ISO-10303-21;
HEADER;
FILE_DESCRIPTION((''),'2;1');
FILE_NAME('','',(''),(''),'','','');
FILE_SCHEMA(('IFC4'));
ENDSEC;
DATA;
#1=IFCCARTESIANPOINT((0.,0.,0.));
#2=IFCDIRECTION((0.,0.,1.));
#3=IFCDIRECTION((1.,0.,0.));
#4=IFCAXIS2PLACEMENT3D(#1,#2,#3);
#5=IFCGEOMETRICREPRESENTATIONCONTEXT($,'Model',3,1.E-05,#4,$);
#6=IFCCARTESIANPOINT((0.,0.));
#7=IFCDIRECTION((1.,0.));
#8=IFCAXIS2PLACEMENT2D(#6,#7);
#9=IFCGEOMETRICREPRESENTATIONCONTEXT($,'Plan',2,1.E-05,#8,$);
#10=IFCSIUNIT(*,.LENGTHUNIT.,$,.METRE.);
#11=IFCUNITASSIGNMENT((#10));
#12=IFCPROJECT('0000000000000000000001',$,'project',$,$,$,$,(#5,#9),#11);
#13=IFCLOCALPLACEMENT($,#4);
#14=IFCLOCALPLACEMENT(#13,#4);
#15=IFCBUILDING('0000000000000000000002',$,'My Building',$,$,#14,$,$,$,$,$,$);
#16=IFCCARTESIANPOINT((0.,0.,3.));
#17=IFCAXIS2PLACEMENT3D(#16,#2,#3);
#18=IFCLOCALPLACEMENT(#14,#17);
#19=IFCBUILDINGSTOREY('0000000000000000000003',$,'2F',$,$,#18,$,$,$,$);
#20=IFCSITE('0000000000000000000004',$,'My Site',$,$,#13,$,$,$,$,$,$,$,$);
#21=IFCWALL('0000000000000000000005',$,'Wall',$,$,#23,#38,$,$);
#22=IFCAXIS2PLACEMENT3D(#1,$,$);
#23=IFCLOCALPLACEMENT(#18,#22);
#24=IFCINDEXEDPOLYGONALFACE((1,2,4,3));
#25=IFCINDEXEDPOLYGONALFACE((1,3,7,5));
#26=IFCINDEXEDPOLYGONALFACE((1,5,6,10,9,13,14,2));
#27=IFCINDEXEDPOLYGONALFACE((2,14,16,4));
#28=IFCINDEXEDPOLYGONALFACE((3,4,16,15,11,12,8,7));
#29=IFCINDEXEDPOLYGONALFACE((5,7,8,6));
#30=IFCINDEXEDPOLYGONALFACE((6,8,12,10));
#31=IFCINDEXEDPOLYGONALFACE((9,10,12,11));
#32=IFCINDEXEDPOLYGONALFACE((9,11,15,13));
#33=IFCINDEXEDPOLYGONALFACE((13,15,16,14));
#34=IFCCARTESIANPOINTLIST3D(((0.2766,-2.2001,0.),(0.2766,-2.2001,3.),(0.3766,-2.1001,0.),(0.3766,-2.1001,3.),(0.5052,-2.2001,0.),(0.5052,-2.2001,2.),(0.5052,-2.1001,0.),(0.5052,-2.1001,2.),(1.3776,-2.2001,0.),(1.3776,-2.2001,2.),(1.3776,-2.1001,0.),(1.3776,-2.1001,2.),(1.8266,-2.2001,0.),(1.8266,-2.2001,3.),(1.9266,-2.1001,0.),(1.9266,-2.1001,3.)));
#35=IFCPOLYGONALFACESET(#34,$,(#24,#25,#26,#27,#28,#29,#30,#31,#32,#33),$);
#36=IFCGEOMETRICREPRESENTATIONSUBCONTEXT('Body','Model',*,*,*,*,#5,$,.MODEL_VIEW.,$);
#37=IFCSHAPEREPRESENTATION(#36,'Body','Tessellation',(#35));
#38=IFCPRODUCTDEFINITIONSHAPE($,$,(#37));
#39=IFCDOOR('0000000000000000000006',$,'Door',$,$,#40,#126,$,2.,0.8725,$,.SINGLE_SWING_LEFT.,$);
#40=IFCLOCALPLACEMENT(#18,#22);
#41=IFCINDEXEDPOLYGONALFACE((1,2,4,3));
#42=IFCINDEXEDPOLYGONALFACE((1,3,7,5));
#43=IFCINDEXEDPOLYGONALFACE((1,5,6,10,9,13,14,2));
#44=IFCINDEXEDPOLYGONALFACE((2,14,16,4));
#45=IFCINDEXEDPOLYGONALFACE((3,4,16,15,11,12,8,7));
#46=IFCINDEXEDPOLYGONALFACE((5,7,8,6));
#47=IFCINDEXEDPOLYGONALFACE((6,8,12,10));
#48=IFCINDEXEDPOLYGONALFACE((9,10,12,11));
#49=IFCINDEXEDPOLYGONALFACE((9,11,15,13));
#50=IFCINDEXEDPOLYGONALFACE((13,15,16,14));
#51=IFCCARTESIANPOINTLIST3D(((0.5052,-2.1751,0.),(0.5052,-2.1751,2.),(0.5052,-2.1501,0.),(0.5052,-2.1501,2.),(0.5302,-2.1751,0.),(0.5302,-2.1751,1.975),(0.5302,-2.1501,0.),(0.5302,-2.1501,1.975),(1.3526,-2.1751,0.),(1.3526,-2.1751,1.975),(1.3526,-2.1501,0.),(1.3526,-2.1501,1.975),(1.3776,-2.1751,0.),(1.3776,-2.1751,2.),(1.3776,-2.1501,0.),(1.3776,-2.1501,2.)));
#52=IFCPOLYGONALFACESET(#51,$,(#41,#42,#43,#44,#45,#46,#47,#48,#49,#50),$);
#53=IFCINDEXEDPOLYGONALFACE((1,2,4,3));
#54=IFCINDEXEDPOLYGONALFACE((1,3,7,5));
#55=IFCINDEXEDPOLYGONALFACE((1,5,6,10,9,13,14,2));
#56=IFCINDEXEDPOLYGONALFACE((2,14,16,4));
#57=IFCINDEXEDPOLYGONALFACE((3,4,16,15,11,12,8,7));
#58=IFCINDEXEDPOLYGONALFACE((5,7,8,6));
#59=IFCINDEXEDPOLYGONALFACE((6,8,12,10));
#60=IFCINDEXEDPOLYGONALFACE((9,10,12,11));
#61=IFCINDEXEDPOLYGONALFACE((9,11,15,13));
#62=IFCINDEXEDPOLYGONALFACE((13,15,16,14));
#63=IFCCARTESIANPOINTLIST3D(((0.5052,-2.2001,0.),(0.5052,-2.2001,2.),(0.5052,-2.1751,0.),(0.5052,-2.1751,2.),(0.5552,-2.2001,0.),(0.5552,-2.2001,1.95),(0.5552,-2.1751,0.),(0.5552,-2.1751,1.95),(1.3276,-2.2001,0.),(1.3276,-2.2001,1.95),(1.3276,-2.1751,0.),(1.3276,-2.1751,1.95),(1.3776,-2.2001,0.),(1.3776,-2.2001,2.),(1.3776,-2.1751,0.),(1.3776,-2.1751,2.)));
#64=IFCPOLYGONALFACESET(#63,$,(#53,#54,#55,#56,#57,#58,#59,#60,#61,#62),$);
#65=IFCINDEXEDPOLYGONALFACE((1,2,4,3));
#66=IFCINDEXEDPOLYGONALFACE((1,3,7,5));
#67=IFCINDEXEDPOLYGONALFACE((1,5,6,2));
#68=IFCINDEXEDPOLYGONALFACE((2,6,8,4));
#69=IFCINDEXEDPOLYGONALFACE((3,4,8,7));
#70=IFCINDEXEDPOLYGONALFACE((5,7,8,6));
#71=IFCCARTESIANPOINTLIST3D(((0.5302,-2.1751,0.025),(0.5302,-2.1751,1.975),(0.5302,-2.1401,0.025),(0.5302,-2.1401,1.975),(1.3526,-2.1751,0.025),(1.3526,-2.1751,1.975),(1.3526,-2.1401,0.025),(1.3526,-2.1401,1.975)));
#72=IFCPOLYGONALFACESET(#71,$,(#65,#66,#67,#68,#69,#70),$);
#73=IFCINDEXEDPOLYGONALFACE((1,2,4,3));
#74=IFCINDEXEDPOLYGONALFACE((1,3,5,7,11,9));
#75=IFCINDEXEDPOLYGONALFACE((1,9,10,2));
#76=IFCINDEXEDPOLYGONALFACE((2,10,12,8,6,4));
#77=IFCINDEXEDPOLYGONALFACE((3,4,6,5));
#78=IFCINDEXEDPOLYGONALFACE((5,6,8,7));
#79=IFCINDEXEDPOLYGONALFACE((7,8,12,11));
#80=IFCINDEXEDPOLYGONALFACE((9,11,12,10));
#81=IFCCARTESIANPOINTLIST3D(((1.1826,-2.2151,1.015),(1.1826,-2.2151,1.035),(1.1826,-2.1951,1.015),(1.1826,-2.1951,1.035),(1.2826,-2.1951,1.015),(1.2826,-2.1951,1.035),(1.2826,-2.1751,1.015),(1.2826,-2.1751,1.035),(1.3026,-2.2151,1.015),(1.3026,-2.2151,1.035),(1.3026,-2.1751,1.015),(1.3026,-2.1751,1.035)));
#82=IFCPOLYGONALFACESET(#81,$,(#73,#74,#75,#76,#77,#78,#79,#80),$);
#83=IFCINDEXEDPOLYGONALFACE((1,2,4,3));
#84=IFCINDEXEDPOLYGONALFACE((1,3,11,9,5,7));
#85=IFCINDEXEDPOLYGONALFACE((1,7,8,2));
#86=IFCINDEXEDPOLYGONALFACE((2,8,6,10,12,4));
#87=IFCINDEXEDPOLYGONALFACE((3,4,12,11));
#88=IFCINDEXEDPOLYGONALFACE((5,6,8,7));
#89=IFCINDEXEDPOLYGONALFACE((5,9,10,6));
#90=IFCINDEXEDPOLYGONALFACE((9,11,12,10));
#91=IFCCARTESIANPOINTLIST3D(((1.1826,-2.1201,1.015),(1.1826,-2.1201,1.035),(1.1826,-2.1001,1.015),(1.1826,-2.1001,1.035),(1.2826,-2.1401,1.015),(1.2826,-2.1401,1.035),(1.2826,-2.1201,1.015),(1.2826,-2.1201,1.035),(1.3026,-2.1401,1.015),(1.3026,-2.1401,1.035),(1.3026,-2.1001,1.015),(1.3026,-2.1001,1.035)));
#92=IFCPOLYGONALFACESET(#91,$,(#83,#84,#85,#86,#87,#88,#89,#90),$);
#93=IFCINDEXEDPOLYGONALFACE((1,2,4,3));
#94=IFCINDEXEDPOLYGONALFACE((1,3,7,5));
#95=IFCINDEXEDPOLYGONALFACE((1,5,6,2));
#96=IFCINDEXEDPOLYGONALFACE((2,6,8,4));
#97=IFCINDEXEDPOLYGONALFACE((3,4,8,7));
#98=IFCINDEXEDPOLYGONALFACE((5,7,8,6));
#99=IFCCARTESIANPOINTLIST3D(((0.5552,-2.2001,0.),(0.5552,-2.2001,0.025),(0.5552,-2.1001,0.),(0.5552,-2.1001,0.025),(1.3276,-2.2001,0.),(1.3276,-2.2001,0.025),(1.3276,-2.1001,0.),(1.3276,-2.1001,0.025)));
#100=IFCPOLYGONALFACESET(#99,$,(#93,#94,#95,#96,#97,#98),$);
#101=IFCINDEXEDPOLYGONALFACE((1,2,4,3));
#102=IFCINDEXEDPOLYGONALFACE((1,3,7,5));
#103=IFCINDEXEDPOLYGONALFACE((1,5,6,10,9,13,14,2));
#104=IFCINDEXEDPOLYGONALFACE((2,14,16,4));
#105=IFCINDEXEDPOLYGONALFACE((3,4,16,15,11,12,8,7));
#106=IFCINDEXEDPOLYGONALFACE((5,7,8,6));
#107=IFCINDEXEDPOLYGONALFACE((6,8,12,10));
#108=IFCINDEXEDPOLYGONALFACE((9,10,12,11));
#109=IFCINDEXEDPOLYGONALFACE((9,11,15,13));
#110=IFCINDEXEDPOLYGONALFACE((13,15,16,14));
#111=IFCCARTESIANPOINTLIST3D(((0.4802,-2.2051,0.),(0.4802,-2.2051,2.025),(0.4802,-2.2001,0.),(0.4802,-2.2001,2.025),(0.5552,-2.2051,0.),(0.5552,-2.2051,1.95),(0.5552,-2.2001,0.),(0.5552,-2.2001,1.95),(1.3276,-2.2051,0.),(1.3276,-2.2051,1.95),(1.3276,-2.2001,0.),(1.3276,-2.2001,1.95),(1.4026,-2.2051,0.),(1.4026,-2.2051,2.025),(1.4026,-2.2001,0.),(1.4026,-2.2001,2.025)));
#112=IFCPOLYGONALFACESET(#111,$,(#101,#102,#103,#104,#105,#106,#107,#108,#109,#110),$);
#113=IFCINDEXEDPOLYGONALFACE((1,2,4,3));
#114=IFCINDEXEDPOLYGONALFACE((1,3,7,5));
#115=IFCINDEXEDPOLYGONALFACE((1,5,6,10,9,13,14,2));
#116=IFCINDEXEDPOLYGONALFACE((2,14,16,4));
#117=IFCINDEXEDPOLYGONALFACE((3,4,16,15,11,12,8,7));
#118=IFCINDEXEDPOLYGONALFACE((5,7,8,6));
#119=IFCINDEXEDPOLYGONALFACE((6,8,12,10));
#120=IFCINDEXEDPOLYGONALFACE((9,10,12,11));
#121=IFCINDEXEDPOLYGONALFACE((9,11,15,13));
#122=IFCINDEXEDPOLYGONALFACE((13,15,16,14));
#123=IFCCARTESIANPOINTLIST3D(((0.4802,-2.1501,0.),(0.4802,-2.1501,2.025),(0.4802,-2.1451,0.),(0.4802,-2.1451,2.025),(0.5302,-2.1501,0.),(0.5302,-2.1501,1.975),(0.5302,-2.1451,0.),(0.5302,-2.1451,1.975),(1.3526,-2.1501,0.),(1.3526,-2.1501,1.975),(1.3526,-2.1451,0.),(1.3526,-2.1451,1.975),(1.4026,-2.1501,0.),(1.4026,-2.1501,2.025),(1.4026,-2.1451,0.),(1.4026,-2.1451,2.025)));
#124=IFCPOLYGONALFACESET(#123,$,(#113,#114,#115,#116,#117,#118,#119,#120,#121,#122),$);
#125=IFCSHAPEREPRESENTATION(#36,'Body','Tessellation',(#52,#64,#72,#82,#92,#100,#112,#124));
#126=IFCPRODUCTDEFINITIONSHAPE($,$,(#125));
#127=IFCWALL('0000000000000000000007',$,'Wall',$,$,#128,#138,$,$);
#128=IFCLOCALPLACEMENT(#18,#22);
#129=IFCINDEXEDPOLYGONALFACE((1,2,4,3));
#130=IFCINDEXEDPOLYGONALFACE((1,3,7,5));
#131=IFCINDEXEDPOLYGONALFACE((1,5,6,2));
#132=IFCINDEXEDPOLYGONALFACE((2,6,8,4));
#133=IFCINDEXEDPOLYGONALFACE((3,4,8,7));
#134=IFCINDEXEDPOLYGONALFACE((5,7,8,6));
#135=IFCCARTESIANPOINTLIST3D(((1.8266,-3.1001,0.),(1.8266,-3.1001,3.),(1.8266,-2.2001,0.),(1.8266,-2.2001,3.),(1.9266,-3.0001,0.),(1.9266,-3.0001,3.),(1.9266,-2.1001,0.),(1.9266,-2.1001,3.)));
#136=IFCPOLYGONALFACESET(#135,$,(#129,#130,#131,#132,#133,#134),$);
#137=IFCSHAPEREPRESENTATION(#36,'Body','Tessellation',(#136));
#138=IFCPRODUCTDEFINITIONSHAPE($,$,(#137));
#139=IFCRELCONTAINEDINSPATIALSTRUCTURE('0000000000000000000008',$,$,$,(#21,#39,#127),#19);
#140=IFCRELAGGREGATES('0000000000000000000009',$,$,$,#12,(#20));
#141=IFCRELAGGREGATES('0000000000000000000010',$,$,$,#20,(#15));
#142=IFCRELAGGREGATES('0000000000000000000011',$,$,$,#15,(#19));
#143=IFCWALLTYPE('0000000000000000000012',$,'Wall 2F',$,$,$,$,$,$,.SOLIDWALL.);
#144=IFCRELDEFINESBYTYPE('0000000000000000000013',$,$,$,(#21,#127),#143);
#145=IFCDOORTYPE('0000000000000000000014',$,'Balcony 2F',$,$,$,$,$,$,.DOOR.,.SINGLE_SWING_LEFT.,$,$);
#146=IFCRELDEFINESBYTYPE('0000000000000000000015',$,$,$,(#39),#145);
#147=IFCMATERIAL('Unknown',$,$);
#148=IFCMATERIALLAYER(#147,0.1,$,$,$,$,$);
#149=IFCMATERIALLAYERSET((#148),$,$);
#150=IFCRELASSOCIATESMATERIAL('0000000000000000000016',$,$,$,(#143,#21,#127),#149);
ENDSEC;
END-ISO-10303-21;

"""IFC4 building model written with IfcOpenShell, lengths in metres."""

from ifc_helpers import new_model, entity, si_unit, frame, origin_with_axes, origin_2d_with_axis, place, context, subcontext, project, spatial, line, indexed_curve, outline, extrude, shape, source, transform, mapped, material, layer, layer_set, layer_usage, type_object, type_shapes, element, fill, save


model = new_model("IFC4")

# Units and contexts
model_context = context("Model", 3, precision=1e-05, world=origin_with_axes())
plan_context = context("Plan", 2, precision=1e-05, world=origin_2d_with_axis())
body_context_1 = subcontext(model_context, "Body", "Model", "MODEL_VIEW")
body_context_2 = subcontext(plan_context, "Body", "Plan", "PLAN_VIEW")
ifc_project = project(units=[si_unit("LENGTHUNIT", "METRE")], contexts=[model_context, plan_context])

# Site, building, storey
site_placement = place(None, origin_with_axes())
site = spatial("IfcSite", under=ifc_project, at=site_placement, Name="My Site")
building_placement = place(site_placement, origin_with_axes())
building = spatial("IfcBuilding", under=site, at=building_placement, Name="My Building")
storey_placement = place(building_placement, frame((0.0, 0.0, 3.0), z_axis=(0.0, 0.0, 1.0), x_axis=(1.0, 0.0, 0.0)))
storey = spatial("IfcBuildingStorey", under=building, at=storey_placement, Name="2F")

# Shared definitions
ifc_material = material(Name="Unknown")

# Shared definitions
ifc_layer = layer(ifc_material, 0.1)
ifc_layer_set = layer_set([ifc_layer])
wall_type = type_object("IfcWallType", Name="Wall 2F", PredefinedType="SOLIDWALL", material=ifc_layer_set)

# Wall, opening, door
ifc_layer_usage_1 = layer_usage(ifc_layer_set, "AXIS2", "POSITIVE", 0.0)
wall_1_placement = place(storey_placement, frame((0.2766, -2.2001, 0.0), z_axis=(0.0, 0.0, 1.0), x_axis=(1.0, 0.0, 0.0)))
wall_1 = element("IfcWall", 1, at=wall_1_placement, inside=storey, type_object=wall_type, material=ifc_layer_usage_1, Name="Wall", context=body_context_1, shape_type="SweptSolid", body=[
    extrude(outline(indexed_curve([(0.0, 0.0), (0.1, 0.1), (1.65, 0.1), (1.55, 0.0)], segments=[line(1, 2, 3, 4, 1)])), origin_with_axes(), (0.0, 0.0, 1.0), 3.0),
])
shared_shape_1 = source(origin_with_axes(), body_context_1, "Body", "SweptSolid", [
    extrude(outline(indexed_curve([(0.0, 0.0), (0.8725, 0.0), (0.8725, 2.0), (0.0, 2.0)], segments=[line(1, 2, 3, 4, 1)])), frame((0.0, -0.6, 0.0), z_axis=(0.0, -1.0, 0.0), x_axis=(1.0, 0.0, 0.0)), (0.0, 0.0, -1.0), 1.2),
])
opening_1_placement = place(wall_1_placement, frame((0.2286, 0.0, 0.0), z_axis=(0.0, 0.0, 1.0), x_axis=(1.0, 0.0, 0.0)))
opening_1 = element("IfcOpeningElement", 2, at=opening_1_placement, cuts=wall_1, PredefinedType="OPENING", context=body_context_1, shape_type="MappedRepresentation", body=[
    mapped(shared_shape_1, transform((0.0, 0.0, 0.0), x_axis=(1.0, 0.0, 0.0), y_axis=(0.0, 1.0, 0.0), z_axis=(0.0, 0.0, 1.0), scale=1.0)),
])
door_type_1 = type_object("IfcDoorType", Name="Balcony 2F", OperationType="SINGLE_SWING_LEFT", PredefinedType="DOOR")
shared_shape_2 = source(origin_with_axes(), body_context_1, "Body", "SweptSolid", [
    extrude(outline(indexed_curve([(0.0, 0.0), (0.0, 2.0), (0.8725, 2.0), (0.8725, 0.0), (0.8475, 0.0), (0.8475, 1.975), (0.025, 1.975), (0.025, 0.0)], segments=[line(1, 2, 3, 4, 5, 6, 7, 8, 1)])), frame((0.0, 0.025, 0.0), z_axis=(0.0, -1.0, 0.0), x_axis=(1.0, 0.0, 0.0)), (0.0, 0.0, -1.0), 0.025),
    extrude(outline(indexed_curve([(0.0, 0.0), (0.0, 2.0), (0.8725, 2.0), (0.8725, 0.0), (0.8225, 0.0), (0.8225, 1.95), (0.05, 1.95), (0.05, 0.0)], segments=[line(1, 2, 3, 4, 5, 6, 7, 8, 1)])), frame((0.0, 0.0, 0.0), z_axis=(0.0, -1.0, 0.0), x_axis=(1.0, 0.0, 0.0)), (0.0, 0.0, -1.0), 0.025),
    extrude(outline(indexed_curve([(0.0, 0.0), (0.8225, 0.0), (0.8225, 0.035), (0.0, 0.035)], segments=[line(1, 2, 3, 4, 1)])), frame((0.025, 0.025, 0.025), z_axis=(0.0, 0.0, 1.0), x_axis=(1.0, 0.0, 0.0)), (0.0, 0.0, 1.0), 1.95),
    extrude(outline(indexed_curve([(0.0, 0.0), (0.0, -0.04), (-0.12, -0.04), (-0.12, -0.02), (-0.02, -0.02), (-0.02, 0.0)], segments=[line(1, 2, 3, 4, 5, 6, 1)])), frame((0.7975, 0.025, 1.015), z_axis=(0.0, 0.0, 1.0), x_axis=(1.0, 0.0, 0.0)), (0.0, 0.0, 1.0), 0.02),
    extrude(outline(indexed_curve([(0.0, 0.0), (0.0, 0.04), (-0.12, 0.04), (-0.12, 0.02), (-0.02, 0.02), (-0.02, 0.0)], segments=[line(1, 2, 3, 4, 5, 6, 1)])), frame((0.7975, 0.06, 1.015), z_axis=(0.0, 0.0, 1.0), x_axis=(1.0, 0.0, 0.0)), (0.0, 0.0, 1.0), 0.02),
    extrude(outline(indexed_curve([(0.0, 0.0), (0.7725, 0.0), (0.7725, 0.1), (0.0, 0.1)], segments=[line(1, 2, 3, 4, 1)])), frame((0.05, 0.0, 0.0), z_axis=(0.0, 0.0, 1.0), x_axis=(1.0, 0.0, 0.0)), (0.0, 0.0, 1.0), 0.025),
    extrude(outline(indexed_curve([(0.0, 0.0), (0.0, 2.025), (0.9225, 2.025), (0.9225, 0.0), (0.8475, 0.0), (0.8475, 1.95), (0.075, 1.95), (0.075, 0.0)], segments=[line(1, 2, 3, 4, 5, 6, 7, 8, 1)])), frame((-0.025, -0.005, 0.0), z_axis=(0.0, -1.0, 0.0), x_axis=(1.0, 0.0, 0.0)), (0.0, 0.0, -1.0), 0.005),
    extrude(outline(indexed_curve([(0.0, 0.0), (0.0, 2.025), (0.9225, 2.025), (0.9225, 0.0), (0.8725, 0.0), (0.8725, 1.975), (0.05, 1.975), (0.05, 0.0)], segments=[line(1, 2, 3, 4, 5, 6, 7, 8, 1)])), frame((-0.025, 0.05, 0.0), z_axis=(0.0, -1.0, 0.0), x_axis=(1.0, 0.0, 0.0)), (0.0, 0.0, -1.0), 0.005),
])
shared_shape_3 = source(origin_with_axes(), body_context_2, "Body", "Curve2D", [
    entity("IfcIndexedPolyCurve", entity("IfcCartesianPointList2D", [[0.0, 0.0], [0.0, 0.05], [0.025, 0.05], [0.025, 0.025], [0.05, 0.025], [0.05, 0.0]]), [entity("IfcLineIndex", [1, 2, 3, 4, 5, 6, 1])]),
    entity("IfcIndexedPolyCurve", entity("IfcCartesianPointList2D", [[0.8725, 0.0], [0.8725, 0.05], [0.8475, 0.05], [0.8475, 0.025], [0.8225, 0.025], [0.8225, 0.0]]), [entity("IfcLineIndex", [1, 2, 3, 4, 5, 6, 1])]),
    entity("IfcTrimmedCurve", entity("IfcEllipse", entity("IfcAxis2Placement2D", entity("IfcCartesianPoint", [0.06, 0.05]), entity("IfcDirection", [1.0, 0.0])), 0.7875, 0.8225), [entity("IfcCartesianPoint", [0.8475, 0.05])], [entity("IfcCartesianPoint", [0.06, 0.8725])], True, "CARTESIAN"),
    entity("IfcIndexedPolyCurve", entity("IfcCartesianPointList2D", [[0.025, 0.05], [0.06, 0.05], [0.06, 0.8725], [0.025, 0.8725]]), [entity("IfcLineIndex", [1, 2, 3, 4, 1])]),
])
type_shapes(door_type_1, [shared_shape_2, shared_shape_3])
door_1_placement = place(opening_1_placement, frame((0.0, 0.0, 0.0), z_axis=(0.0, 0.0, 1.0), x_axis=(1.0, 0.0, 0.0)))
door_1 = element("IfcDoor", 3, at=door_1_placement, inside=storey, type_object=door_type_1, Name="Door", OperationType="SINGLE_SWING_LEFT", OverallHeight=2.0, OverallWidth=0.8725, shapes=[
    shape(body_context_1, "Body", "MappedRepresentation", [mapped(shared_shape_2, transform((0.0, 0.0, 0.0), x_axis=(1.0, 0.0, 0.0), y_axis=(0.0, 1.0, 0.0), z_axis=(0.0, 0.0, 1.0), scale=1.0))]),
    shape(body_context_2, "Body", "MappedRepresentation", [mapped(shared_shape_3, transform((0.0, 0.0, 0.0), x_axis=(1.0, 0.0, 0.0), y_axis=(0.0, 1.0, 0.0), z_axis=(0.0, 0.0, 1.0), scale=1.0))]),
])
fill(opening_1, door_1)

# Wall
ifc_layer_usage_2 = layer_usage(ifc_layer_set, "AXIS2", "POSITIVE", 0.0)
wall_2_placement = place(storey_placement, frame((1.8266, -2.2001, 0.0), z_axis=(0.0, 0.0, 1.0), x_axis=(0.0, -1.0, 0.0)))
element("IfcWall", 4, at=wall_2_placement, inside=storey, type_object=wall_type, material=ifc_layer_usage_2, Name="Wall", context=body_context_1, shape_type="SweptSolid", body=[
    extrude(outline(indexed_curve([(0.0, 0.0), (-0.1, 0.1), (0.8, 0.1), (0.9, 0.0)], segments=[line(1, 2, 3, 4, 1)])), origin_with_axes(), (0.0, 0.0, 1.0), 3.0),
])

save(model, "model.ifc")
